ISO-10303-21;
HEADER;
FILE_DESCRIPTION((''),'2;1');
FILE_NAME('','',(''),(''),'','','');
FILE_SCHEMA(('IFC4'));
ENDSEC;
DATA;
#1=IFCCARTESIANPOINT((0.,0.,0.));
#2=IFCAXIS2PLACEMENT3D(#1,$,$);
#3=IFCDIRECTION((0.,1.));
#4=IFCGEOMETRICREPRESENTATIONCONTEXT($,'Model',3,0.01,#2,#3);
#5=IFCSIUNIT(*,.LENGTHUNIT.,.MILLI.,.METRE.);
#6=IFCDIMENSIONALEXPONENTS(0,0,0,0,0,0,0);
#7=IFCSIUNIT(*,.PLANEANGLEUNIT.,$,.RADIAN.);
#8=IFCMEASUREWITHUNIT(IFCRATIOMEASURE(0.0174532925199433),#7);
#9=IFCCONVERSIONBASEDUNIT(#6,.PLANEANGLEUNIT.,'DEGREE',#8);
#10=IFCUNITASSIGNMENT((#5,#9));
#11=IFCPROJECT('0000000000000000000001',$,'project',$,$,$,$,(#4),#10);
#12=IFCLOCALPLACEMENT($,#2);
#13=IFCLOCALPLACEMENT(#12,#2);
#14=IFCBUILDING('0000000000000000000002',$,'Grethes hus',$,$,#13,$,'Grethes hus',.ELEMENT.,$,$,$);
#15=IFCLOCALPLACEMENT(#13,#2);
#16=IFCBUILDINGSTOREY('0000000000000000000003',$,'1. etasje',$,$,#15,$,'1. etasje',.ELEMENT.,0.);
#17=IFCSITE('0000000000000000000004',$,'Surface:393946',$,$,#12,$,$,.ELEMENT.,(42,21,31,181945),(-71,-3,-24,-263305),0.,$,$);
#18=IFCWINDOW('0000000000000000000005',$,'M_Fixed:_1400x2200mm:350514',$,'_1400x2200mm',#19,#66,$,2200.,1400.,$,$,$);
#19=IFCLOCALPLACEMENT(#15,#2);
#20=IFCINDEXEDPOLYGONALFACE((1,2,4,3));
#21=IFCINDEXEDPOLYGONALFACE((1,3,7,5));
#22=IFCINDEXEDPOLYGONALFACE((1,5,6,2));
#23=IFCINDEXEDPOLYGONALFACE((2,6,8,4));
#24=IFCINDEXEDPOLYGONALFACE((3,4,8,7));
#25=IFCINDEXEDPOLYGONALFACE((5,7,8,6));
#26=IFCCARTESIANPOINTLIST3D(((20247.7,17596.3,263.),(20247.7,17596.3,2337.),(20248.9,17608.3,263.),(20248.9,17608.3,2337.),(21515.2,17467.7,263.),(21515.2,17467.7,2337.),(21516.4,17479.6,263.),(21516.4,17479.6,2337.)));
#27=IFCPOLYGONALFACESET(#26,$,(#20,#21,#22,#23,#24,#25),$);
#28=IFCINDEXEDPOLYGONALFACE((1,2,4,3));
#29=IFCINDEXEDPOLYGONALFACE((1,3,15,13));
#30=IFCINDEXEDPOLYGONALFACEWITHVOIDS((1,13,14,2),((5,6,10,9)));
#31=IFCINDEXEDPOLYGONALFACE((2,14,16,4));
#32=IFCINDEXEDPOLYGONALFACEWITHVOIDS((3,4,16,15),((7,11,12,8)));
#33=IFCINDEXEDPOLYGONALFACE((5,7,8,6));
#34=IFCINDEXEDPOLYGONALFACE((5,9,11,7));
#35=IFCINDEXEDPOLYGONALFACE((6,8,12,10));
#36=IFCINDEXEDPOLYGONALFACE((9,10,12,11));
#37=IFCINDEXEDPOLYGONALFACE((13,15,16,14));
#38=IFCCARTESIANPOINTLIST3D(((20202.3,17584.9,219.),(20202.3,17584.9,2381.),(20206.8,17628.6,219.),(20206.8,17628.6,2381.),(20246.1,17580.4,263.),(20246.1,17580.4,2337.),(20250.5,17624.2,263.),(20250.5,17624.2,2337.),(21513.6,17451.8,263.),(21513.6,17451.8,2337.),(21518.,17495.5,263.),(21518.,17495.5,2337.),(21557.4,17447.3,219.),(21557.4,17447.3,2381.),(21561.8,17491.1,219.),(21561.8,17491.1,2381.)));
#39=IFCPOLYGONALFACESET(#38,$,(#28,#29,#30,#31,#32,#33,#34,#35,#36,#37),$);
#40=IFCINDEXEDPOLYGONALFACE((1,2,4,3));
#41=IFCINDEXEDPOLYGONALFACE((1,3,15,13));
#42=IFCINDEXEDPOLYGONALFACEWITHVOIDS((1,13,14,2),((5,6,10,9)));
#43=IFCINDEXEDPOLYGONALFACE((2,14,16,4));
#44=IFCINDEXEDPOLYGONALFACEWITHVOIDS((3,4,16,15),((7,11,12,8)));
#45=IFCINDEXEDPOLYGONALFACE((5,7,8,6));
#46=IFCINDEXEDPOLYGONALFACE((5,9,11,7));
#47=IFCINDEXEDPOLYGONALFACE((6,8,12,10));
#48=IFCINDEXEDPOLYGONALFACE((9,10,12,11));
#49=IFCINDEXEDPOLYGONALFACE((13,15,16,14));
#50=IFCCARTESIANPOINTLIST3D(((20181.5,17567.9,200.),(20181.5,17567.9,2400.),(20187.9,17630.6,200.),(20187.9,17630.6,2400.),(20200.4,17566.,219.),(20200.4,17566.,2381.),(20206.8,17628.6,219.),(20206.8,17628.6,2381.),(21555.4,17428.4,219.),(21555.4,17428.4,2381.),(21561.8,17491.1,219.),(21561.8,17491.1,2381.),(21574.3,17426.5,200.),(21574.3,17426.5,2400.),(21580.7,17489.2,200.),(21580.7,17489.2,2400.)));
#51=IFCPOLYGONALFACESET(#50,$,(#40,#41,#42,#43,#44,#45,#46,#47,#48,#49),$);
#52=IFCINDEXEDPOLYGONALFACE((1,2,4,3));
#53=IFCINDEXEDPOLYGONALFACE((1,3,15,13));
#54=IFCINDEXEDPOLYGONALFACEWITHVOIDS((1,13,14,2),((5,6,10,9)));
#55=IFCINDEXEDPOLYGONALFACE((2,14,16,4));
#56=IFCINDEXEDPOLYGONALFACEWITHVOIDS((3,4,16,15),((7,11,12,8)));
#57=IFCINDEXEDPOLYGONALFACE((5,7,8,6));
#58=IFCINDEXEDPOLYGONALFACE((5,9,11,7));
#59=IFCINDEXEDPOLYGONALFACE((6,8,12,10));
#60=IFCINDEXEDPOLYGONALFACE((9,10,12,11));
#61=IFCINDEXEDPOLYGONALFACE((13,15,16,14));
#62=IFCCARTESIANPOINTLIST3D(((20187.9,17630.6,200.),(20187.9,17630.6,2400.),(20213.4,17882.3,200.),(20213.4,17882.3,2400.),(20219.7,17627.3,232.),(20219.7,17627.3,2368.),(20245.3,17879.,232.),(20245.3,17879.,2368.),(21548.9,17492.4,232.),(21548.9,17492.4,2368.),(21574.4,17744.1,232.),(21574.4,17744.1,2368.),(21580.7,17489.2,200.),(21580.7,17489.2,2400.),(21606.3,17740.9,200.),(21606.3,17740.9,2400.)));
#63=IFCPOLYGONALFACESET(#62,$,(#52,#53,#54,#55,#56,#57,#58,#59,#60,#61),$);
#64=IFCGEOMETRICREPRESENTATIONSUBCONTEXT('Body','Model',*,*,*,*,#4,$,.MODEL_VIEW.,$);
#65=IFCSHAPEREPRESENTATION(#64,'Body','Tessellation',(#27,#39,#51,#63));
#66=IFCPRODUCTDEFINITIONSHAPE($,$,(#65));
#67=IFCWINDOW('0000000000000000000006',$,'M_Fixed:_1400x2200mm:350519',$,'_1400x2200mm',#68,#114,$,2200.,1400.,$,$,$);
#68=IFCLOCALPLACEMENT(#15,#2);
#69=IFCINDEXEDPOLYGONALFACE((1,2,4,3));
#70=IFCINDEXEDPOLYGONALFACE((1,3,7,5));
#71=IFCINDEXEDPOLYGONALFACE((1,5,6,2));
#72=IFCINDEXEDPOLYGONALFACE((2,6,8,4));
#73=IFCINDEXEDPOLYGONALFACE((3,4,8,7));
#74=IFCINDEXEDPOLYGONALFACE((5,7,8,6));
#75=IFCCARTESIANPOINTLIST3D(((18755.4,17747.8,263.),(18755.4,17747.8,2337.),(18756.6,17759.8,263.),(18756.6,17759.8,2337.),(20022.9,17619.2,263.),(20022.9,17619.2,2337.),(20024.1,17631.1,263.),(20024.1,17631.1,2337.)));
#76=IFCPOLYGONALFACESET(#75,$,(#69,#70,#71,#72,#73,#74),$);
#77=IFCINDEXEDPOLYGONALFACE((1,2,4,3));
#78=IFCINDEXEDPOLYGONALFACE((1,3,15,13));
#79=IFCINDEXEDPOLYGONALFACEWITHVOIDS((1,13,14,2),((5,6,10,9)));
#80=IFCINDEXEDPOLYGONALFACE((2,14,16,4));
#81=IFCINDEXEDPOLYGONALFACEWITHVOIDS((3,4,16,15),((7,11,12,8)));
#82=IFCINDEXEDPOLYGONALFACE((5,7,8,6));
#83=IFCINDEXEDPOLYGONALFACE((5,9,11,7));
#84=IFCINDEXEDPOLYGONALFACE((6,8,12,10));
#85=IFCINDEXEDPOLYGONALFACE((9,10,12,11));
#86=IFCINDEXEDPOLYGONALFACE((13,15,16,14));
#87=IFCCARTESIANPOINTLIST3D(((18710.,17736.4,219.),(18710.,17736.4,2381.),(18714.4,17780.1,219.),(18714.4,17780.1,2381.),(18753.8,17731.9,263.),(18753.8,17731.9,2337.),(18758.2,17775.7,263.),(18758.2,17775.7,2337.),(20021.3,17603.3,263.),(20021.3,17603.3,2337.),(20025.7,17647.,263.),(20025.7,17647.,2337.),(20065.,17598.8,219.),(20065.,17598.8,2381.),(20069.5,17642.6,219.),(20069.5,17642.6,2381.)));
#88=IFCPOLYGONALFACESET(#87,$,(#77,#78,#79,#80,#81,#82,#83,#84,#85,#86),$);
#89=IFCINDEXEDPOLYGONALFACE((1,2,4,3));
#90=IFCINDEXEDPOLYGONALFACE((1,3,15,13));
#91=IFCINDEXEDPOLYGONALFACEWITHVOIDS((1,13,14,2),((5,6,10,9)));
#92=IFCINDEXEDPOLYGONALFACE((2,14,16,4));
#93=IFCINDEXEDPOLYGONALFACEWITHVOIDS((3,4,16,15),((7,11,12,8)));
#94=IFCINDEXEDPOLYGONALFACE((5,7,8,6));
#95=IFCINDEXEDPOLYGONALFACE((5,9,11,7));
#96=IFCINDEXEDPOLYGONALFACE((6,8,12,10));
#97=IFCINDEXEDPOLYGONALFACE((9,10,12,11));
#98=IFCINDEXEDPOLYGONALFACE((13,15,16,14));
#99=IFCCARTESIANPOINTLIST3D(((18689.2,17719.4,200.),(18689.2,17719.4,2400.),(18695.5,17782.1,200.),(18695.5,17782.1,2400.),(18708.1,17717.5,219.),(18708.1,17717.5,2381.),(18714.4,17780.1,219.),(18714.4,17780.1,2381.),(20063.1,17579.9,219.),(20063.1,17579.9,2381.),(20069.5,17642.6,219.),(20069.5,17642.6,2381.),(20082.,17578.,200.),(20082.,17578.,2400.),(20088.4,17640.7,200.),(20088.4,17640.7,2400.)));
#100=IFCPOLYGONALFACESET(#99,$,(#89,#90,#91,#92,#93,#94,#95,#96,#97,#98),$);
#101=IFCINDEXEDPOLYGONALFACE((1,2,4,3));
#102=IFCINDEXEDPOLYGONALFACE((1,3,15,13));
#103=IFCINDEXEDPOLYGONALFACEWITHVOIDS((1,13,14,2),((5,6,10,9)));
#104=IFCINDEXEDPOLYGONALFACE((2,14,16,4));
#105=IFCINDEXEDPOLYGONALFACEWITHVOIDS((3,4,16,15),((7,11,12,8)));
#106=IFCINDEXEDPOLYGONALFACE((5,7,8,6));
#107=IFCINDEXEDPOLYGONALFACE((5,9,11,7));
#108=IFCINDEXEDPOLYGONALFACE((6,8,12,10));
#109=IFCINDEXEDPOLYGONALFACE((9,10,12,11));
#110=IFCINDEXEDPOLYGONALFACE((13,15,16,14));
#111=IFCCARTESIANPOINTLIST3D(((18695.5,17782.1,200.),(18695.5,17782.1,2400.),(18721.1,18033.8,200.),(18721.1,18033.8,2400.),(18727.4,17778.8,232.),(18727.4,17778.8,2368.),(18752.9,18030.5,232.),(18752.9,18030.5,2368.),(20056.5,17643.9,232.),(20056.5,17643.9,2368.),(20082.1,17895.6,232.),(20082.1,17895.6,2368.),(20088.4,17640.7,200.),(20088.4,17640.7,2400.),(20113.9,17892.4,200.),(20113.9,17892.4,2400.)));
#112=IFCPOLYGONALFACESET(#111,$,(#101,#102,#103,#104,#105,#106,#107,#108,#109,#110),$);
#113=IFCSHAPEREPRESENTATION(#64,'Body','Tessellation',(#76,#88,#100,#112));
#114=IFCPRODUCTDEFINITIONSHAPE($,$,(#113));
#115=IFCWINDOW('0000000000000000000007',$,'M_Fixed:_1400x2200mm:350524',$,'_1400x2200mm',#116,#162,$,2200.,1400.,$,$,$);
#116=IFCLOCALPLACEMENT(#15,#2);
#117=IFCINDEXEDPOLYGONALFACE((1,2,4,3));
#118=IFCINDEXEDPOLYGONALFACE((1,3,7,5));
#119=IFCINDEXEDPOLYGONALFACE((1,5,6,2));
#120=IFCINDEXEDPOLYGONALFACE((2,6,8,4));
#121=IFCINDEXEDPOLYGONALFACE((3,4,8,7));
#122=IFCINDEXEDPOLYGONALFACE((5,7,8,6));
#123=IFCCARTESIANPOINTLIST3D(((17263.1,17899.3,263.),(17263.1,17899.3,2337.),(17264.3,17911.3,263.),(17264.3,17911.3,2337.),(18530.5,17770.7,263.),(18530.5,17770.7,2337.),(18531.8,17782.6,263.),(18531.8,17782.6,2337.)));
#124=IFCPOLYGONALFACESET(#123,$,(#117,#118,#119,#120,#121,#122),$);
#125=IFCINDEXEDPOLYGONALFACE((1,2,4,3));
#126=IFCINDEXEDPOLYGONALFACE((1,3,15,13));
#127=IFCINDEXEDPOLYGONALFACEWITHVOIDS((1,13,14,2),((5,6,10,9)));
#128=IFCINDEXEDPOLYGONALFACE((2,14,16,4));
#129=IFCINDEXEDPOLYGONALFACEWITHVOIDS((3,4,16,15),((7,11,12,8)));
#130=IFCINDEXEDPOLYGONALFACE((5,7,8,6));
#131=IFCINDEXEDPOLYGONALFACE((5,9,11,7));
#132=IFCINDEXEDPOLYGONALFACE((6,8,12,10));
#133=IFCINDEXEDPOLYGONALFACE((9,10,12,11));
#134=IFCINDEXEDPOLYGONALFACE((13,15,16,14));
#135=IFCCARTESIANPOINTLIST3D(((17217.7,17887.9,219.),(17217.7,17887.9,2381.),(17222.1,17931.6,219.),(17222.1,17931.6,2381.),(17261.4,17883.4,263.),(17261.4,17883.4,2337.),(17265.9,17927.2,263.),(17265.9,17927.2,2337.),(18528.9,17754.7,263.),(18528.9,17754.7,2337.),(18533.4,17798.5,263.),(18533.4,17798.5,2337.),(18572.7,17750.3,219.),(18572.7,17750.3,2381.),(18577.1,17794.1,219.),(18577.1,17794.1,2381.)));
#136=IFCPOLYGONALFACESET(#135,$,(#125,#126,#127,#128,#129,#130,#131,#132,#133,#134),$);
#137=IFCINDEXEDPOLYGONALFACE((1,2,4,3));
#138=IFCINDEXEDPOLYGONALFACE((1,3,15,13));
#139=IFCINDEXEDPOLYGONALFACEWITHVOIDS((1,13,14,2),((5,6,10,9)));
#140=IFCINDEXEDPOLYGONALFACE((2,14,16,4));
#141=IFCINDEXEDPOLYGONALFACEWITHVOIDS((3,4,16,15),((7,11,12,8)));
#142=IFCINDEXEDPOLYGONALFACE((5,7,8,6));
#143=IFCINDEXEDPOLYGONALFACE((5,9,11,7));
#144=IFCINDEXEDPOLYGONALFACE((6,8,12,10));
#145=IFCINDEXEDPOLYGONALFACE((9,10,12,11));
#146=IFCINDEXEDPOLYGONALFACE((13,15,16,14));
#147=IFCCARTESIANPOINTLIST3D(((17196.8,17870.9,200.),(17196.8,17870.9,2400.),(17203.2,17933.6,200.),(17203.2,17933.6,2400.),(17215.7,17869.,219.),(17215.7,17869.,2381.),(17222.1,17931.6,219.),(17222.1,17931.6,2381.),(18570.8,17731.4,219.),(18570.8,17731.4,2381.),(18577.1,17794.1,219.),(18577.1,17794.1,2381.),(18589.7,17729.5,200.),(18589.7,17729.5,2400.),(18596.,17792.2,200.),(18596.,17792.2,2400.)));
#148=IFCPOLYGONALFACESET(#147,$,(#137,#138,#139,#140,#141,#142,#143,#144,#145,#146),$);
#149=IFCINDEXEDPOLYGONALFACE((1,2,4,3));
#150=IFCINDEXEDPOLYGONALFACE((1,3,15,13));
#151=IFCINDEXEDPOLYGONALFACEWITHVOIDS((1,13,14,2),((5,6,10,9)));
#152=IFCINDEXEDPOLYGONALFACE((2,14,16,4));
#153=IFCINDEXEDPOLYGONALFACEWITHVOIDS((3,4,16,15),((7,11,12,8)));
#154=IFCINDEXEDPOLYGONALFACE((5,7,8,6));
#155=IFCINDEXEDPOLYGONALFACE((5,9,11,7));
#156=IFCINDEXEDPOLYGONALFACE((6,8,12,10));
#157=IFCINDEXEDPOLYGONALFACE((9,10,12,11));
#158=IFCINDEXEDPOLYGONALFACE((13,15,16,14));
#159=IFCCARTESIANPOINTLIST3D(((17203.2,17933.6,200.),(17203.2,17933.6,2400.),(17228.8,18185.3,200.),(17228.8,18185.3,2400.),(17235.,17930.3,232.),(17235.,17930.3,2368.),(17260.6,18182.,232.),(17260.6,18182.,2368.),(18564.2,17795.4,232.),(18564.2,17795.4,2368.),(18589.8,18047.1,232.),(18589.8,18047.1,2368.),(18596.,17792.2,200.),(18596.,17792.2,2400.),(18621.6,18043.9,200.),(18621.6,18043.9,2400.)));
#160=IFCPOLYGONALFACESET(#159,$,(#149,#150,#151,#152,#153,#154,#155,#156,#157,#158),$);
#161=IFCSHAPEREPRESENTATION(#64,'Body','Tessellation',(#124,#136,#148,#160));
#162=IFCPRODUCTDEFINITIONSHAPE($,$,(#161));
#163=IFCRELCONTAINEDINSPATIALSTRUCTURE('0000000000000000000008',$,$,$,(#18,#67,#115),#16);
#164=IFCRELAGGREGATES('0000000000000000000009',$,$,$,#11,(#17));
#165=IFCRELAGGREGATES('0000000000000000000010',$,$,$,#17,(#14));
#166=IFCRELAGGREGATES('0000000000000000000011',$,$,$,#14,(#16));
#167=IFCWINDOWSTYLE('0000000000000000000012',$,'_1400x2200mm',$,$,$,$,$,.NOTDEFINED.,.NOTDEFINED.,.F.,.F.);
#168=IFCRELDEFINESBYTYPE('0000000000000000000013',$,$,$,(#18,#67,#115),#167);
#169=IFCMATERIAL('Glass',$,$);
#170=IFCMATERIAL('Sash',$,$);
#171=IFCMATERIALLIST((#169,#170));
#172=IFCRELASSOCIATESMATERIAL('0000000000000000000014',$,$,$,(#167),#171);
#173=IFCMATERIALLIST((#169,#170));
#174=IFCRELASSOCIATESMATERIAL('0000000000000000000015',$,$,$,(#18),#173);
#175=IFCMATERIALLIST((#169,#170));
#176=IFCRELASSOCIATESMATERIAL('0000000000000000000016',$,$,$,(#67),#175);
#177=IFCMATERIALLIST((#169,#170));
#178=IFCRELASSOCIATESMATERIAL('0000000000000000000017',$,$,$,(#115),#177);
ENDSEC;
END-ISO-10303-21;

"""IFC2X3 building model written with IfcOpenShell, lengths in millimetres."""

from ifc_helpers import new_model, entity, si_unit, converted_unit, direction, frame, frame_2d, origin, place, context, subcontext, project, spatial, polyline, rectangle, outline, extrude, source, transform, mapped, material, material_list, type_object, type_shapes, element, save


model = new_model("IFC2X3")

# Units and contexts
model_context = context("Model", 3, precision=0.01, world=origin(), true_north=direction((0.0, 1.0)))
body_context = subcontext(model_context, "Body", "Model", "MODEL_VIEW")
ifc_project = project(units=[si_unit("LENGTHUNIT", "METRE", prefix="MILLI"), converted_unit("PLANEANGLEUNIT", "DEGREE", entity("IfcRatioMeasure", 0.0174532925199433), si_unit("PLANEANGLEUNIT", "RADIAN"), dimensions=[0, 0, 0, 0, 0, 0, 0])], contexts=[model_context])

# Site, building, storey
site_placement = place(None, origin())
site = spatial("IfcSite", under=ifc_project, at=site_placement, Name="Surface:393946", CompositionType="ELEMENT", RefLatitude=(42, 21, 31, 181945), RefLongitude=(-71, -3, -24, -263305), RefElevation=0.0)
building_placement = place(site_placement, origin())
building = spatial("IfcBuilding", under=site, at=building_placement, Name="Grethes hus", LongName="Grethes hus", CompositionType="ELEMENT")
storey_placement = place(building_placement, origin())
storey = spatial("IfcBuildingStorey", under=building, at=storey_placement, Name="1. etasje", LongName="1. etasje", CompositionType="ELEMENT", Elevation=0.0)

# Windows
ifc_material_1 = material(Name="Glass")
ifc_material_2 = material(Name="Sash")
ifc_material_list_1 = material_list([ifc_material_1, ifc_material_2])
window_style_1 = type_object("IfcWindowStyle", Name="_1400x2200mm", ConstructionType="NOTDEFINED", OperationType="NOTDEFINED", ParameterTakesPrecedence=False, Sizeable=False, material=ifc_material_list_1)
shared_shape_1 = source(origin(), body_context, "Body", "SweptSolid", [
    extrude(rectangle(XDim=12.0, YDim=1274.0, at=frame_2d((0.0, 0.0), x_axis=(1.0, 0.0))), frame((700.0, 275.0, 63.0), z_axis=(0.0, 0.0, 1.0), x_axis=(0.0, -1.0, 0.0)), (0.0, 0.0, 1.0), 2074.0),
    extrude(outline(polyline([(-681.0, -1081.0), (681.0, -1081.0), (681.0, 1081.0), (-681.0, 1081.0), (-681.0, -1081.0)]), holes=[polyline([(-637.0, -1037.0), (-637.0, 1037.0), (637.0, 1037.0), (637.0, -1037.0), (-637.0, -1037.0)])]), frame((700.0, 253.0, 1100.0), z_axis=(0.0, 1.0, 0.0), x_axis=(1.0, 0.0, 0.0)), (0.0, 0.0, 1.0), 44.0),
    extrude(outline(polyline([(-700.0, -1100.0), (700.0, -1100.0), (700.0, 1100.0), (-700.0, 1100.0), (-700.0, -1100.0)]), holes=[polyline([(-681.0, -1081.0), (-681.0, 1081.0), (681.0, 1081.0), (681.0, -1081.0), (-681.0, -1081.0)])]), frame((700.0, 253.0, 1100.0), z_axis=(0.0, 1.0, 0.0), x_axis=(1.0, 0.0, 0.0)), (0.0, 0.0, 1.0), 63.0),
    extrude(outline(polyline([(-700.0, -1100.0), (700.0, -1100.0), (700.0, 1100.0), (-700.0, 1100.0), (-700.0, -1100.0)]), holes=[polyline([(-668.0, -1068.0), (-668.0, 1068.0), (668.0, 1068.0), (668.0, -1068.0), (-668.0, -1068.0)])]), frame((700.0, 0.0, 1100.0), z_axis=(0.0, 1.0, 0.0), x_axis=(1.0, 0.0, 0.0)), (0.0, 0.0, 1.0), 253.0),
])
type_shapes(window_style_1, [shared_shape_1])
placement_1 = place(storey_placement, frame((35426.2, 16179.1, 0.0), z_axis=(0.0, 0.0, 1.0), x_axis=(-0.994887, 0.100996, 0.0)))
ifc_material_list_2 = material_list([ifc_material_1, ifc_material_2])
placement_2 = place(placement_1, frame((13907.0, -158.0, 200.0)))
window_1_placement = place(placement_2, origin())
element("IfcWindow", 1, at=window_1_placement, inside=storey, type_object=window_style_1, material=ifc_material_list_2, Name="M_Fixed:_1400x2200mm:350514", ObjectType="_1400x2200mm", OverallHeight=2200.0, OverallWidth=1400.0, context=body_context, shape_type="MappedRepresentation", body=[
    mapped(shared_shape_1, transform((0.0, 0.0, 0.0), scale=1.0)),
])
ifc_material_list_3 = material_list([ifc_material_1, ifc_material_2])
placement_3 = place(placement_1, frame((15407.0, -158.0, 200.0)))
window_2_placement = place(placement_3, origin())
element("IfcWindow", 2, at=window_2_placement, inside=storey, type_object=window_style_1, material=ifc_material_list_3, Name="M_Fixed:_1400x2200mm:350519", ObjectType="_1400x2200mm", OverallHeight=2200.0, OverallWidth=1400.0, context=body_context, shape_type="MappedRepresentation", body=[
    mapped(shared_shape_1, transform((0.0, 0.0, 0.0), scale=1.0)),
])
ifc_material_list_4 = material_list([ifc_material_1, ifc_material_2])
placement_4 = place(placement_1, frame((16907.0, -158.0, 200.0)))
window_3_placement = place(placement_4, origin())
element("IfcWindow", 3, at=window_3_placement, inside=storey, type_object=window_style_1, material=ifc_material_list_4, Name="M_Fixed:_1400x2200mm:350524", ObjectType="_1400x2200mm", OverallHeight=2200.0, OverallWidth=1400.0, context=body_context, shape_type="MappedRepresentation", body=[
    mapped(shared_shape_1, transform((0.0, 0.0, 0.0), scale=1.0)),
])

save(model, "model.ifc")
